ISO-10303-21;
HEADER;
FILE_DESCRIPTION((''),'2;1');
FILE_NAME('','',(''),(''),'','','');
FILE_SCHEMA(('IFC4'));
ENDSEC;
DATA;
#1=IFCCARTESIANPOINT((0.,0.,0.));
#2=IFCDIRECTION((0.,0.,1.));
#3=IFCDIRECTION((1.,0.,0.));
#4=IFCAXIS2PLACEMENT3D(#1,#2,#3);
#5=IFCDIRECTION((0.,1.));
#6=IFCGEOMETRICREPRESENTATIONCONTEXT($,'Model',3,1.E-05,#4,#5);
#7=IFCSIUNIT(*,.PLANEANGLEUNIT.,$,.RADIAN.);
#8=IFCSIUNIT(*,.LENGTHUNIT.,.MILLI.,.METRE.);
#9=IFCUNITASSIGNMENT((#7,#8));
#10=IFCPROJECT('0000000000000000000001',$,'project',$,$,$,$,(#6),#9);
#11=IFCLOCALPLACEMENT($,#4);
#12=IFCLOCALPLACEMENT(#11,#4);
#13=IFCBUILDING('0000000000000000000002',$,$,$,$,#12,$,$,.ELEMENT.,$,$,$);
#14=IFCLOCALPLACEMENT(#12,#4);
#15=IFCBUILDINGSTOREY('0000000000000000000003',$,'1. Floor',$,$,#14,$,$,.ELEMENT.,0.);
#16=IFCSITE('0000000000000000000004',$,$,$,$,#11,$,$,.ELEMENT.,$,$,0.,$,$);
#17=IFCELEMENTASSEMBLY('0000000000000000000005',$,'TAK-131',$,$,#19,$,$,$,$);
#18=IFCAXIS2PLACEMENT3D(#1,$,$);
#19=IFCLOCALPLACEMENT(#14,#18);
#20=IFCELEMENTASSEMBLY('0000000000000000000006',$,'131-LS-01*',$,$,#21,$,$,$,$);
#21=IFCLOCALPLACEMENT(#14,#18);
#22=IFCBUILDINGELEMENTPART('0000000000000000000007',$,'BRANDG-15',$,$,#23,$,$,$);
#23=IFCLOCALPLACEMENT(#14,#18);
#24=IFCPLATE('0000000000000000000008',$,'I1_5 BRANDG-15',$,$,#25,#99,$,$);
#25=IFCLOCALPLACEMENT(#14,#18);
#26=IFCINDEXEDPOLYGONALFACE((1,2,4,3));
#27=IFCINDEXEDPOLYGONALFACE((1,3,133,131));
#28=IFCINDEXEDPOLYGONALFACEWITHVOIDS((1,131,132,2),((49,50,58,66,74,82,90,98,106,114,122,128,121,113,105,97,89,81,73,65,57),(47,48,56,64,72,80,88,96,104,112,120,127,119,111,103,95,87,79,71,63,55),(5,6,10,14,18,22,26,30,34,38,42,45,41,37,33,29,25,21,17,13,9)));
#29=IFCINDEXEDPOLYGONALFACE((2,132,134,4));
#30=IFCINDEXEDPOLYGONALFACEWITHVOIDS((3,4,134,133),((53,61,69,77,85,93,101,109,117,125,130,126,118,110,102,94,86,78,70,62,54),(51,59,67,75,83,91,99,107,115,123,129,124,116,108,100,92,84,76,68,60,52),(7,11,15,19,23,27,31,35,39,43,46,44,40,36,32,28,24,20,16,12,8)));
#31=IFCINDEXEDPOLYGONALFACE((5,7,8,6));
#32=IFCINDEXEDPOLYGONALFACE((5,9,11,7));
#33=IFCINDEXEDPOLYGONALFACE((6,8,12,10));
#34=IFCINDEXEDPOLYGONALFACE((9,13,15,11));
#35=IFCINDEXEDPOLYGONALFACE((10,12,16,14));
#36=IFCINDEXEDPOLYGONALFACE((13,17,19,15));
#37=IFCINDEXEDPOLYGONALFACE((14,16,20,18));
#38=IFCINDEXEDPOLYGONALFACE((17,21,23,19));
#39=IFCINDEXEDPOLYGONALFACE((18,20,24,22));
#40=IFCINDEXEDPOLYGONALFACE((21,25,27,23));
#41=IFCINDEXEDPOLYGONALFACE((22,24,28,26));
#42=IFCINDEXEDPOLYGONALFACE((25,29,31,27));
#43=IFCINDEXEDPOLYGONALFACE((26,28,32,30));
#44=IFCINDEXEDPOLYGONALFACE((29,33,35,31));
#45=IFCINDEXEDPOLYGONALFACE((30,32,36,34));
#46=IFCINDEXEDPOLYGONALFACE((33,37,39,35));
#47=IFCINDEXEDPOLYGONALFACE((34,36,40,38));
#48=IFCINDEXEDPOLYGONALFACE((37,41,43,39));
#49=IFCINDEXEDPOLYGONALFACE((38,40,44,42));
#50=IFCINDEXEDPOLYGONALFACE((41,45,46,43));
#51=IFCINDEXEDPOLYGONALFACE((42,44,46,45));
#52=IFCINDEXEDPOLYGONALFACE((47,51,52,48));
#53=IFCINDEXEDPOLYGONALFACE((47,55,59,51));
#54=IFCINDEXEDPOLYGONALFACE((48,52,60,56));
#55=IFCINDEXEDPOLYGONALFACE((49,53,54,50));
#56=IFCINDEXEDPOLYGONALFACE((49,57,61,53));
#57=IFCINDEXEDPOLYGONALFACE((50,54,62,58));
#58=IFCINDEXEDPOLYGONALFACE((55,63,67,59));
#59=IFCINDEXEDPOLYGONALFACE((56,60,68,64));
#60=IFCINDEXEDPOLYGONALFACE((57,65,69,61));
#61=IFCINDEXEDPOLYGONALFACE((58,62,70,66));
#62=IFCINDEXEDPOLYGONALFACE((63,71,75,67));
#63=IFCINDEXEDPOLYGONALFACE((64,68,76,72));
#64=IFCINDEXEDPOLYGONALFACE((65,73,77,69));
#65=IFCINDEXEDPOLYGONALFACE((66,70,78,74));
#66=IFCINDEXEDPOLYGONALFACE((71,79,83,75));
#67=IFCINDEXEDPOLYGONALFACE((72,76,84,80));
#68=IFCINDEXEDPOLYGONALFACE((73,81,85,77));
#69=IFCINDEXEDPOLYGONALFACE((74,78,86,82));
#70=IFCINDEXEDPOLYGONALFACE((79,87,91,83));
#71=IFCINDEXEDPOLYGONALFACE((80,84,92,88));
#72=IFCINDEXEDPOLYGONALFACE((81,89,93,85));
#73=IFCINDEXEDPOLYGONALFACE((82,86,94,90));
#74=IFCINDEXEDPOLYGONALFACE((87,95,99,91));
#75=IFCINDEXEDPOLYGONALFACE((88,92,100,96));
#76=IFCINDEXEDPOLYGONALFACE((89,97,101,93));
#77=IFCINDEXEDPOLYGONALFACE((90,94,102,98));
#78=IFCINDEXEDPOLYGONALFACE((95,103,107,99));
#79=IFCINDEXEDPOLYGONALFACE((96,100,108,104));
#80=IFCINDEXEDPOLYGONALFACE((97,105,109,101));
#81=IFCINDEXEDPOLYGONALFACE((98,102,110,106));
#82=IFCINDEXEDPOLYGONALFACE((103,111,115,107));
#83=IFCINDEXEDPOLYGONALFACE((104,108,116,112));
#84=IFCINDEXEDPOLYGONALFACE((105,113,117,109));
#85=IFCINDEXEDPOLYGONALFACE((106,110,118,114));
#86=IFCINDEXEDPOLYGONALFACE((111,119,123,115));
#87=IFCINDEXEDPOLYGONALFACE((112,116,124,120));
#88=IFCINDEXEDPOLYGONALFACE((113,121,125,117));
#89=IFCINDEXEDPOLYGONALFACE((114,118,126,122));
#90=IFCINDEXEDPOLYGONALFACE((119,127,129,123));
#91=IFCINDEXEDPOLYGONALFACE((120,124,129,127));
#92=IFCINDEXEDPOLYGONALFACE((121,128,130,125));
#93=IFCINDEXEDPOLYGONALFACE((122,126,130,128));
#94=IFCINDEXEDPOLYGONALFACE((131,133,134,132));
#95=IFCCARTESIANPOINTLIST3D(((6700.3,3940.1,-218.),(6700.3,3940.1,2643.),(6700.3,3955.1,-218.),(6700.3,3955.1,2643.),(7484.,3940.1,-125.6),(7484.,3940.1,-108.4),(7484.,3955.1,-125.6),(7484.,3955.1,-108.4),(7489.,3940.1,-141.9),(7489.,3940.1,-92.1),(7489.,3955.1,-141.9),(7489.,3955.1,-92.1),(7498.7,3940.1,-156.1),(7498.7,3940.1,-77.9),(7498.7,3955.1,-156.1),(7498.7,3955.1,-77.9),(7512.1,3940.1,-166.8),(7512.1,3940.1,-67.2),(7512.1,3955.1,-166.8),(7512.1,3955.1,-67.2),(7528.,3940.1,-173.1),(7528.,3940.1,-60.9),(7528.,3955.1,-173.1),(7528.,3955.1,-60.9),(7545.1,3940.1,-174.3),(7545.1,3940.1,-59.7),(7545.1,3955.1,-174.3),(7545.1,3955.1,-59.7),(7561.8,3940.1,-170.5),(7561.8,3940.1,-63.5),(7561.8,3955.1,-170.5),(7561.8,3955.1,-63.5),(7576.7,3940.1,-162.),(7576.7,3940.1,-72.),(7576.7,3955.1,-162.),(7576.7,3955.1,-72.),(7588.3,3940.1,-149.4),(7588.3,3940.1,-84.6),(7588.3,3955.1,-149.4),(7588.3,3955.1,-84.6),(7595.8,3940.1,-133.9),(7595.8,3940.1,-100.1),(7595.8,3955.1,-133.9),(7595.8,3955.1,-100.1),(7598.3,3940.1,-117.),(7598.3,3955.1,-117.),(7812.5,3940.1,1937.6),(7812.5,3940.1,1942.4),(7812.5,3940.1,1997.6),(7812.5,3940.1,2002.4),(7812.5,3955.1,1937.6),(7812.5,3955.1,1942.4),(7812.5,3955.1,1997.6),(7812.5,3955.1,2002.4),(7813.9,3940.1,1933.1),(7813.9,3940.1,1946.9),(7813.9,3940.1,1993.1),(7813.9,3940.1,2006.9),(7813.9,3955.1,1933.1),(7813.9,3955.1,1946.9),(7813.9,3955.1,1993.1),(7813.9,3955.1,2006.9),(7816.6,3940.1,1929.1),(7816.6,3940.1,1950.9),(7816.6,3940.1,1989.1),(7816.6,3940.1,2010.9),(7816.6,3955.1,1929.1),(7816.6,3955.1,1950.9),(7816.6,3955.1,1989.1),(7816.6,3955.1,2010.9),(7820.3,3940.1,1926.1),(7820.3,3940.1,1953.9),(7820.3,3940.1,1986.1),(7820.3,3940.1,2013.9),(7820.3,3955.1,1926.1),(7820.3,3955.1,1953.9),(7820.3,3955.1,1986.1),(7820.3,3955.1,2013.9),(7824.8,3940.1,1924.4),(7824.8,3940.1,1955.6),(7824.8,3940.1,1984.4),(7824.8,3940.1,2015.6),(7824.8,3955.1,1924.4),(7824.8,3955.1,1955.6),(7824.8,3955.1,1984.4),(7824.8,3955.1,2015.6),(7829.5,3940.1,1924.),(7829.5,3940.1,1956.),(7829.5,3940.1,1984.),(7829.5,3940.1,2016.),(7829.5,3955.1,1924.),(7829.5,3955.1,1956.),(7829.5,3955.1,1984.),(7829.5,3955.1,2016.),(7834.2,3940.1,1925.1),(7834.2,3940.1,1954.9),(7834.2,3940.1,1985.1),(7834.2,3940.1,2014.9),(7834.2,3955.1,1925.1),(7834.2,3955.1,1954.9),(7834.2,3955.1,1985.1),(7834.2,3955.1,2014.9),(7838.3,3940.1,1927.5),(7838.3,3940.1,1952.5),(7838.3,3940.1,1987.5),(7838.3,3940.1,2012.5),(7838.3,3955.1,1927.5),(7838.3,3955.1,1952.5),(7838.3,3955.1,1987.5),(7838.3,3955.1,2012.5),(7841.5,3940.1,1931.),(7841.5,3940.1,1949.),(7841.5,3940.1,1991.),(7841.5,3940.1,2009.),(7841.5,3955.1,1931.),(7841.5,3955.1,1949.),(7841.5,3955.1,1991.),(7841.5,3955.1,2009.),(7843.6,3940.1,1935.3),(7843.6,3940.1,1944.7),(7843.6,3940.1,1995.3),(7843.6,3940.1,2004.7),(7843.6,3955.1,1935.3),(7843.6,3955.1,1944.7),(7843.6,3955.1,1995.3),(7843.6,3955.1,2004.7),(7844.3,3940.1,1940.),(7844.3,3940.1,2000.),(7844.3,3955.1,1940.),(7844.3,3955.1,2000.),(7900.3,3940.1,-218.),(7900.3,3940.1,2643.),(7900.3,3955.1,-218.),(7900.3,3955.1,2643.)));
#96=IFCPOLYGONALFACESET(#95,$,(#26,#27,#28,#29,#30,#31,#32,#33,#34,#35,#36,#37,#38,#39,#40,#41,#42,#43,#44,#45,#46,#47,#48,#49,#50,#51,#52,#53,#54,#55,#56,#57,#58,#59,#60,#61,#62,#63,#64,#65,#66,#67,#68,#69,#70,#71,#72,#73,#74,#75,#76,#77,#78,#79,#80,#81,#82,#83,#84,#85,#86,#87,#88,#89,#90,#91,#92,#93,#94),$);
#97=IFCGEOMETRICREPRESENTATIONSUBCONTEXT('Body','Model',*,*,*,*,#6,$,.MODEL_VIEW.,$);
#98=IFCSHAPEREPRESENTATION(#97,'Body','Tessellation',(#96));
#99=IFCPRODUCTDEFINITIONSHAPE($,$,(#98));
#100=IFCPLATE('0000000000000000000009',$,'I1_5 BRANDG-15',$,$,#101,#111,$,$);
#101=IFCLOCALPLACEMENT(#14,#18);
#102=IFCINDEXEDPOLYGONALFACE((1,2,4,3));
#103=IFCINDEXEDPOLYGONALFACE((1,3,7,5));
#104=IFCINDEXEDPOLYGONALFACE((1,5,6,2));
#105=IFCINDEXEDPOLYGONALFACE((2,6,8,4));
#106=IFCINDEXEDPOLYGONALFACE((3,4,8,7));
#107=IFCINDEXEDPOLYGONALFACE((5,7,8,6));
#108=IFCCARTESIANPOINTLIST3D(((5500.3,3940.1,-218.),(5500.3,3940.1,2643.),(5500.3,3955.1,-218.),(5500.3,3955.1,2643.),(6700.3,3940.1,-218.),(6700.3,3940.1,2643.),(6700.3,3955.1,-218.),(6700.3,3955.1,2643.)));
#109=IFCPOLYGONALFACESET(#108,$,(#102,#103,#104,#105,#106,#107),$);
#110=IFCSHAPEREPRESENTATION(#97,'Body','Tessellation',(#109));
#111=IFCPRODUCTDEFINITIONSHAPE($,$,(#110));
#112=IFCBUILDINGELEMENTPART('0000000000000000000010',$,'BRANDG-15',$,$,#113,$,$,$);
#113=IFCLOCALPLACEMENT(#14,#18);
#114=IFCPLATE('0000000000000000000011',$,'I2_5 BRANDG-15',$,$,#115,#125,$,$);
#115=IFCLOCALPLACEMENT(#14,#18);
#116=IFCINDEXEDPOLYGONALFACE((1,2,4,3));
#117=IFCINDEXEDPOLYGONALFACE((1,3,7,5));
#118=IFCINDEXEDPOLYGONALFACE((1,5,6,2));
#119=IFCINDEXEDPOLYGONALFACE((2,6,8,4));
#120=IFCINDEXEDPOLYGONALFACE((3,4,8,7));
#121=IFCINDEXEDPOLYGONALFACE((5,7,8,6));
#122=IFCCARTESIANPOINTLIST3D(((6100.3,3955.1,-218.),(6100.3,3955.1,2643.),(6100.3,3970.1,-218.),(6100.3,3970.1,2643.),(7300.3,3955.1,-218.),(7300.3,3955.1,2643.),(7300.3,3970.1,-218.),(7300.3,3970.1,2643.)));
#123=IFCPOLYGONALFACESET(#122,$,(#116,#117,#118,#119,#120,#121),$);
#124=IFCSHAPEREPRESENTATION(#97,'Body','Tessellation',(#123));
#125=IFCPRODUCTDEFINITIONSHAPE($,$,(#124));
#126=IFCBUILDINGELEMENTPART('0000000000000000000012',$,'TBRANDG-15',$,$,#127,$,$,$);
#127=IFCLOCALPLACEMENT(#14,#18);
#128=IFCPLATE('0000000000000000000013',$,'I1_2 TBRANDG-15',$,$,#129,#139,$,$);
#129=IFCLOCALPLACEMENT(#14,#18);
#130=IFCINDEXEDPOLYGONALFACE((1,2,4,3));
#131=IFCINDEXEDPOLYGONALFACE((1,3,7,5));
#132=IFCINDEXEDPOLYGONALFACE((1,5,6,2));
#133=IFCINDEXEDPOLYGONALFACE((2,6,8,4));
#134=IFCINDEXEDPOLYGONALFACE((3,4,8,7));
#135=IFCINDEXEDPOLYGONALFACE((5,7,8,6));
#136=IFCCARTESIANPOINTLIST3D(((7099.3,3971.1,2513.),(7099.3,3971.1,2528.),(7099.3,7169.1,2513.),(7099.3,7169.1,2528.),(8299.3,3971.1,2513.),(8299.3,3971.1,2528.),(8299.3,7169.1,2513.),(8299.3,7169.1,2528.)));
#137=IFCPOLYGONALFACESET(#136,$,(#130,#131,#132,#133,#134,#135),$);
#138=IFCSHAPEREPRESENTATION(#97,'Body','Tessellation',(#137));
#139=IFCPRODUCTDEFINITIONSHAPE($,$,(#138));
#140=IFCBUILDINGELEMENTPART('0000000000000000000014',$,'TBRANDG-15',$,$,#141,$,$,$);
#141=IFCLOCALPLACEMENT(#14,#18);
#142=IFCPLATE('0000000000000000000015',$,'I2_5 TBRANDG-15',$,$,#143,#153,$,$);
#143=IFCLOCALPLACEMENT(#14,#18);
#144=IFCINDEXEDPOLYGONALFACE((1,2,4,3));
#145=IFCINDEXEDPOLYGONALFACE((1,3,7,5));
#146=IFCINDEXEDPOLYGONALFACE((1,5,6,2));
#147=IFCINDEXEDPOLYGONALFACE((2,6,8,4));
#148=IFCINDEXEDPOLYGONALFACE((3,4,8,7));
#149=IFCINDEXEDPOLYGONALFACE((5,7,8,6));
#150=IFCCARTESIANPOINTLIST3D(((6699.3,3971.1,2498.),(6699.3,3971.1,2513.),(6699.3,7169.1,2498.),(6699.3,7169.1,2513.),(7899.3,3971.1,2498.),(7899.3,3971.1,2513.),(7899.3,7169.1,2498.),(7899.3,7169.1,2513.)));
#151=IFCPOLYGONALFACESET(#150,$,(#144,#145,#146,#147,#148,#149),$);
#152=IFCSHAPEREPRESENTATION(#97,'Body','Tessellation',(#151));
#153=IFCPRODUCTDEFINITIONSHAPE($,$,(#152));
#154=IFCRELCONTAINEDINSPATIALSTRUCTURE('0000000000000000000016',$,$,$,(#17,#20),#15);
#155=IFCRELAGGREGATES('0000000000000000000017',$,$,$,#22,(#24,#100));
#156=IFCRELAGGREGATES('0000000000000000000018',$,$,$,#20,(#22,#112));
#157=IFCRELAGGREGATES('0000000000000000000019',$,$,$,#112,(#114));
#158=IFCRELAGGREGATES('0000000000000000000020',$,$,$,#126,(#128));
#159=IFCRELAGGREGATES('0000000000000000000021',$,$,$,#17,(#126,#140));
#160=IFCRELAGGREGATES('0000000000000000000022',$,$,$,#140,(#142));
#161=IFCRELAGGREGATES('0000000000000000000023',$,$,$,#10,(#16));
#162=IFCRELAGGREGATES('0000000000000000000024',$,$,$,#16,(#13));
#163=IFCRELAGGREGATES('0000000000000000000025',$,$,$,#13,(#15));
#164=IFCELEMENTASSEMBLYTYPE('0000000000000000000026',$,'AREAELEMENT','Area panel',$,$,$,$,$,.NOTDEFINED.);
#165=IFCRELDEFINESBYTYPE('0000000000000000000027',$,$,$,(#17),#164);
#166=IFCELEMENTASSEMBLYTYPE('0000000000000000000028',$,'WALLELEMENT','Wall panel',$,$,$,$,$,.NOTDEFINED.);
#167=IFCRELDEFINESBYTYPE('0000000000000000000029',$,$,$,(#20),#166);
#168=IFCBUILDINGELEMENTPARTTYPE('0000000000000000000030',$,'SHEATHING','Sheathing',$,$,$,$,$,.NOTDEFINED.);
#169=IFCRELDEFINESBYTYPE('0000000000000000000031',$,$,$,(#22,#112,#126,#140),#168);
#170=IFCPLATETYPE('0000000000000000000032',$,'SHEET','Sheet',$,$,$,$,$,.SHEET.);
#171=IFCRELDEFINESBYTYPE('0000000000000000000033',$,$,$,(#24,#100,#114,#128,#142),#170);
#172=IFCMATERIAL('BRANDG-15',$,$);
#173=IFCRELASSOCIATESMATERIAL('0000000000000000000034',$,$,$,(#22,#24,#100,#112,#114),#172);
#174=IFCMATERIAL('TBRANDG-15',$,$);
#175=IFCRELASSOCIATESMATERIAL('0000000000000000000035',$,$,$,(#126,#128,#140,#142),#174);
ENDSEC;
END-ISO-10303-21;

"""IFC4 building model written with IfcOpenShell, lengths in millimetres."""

from ifc_helpers import new_model, si_unit, direction, frame, origin_with_axes, origin_2d_with_axis, place, context, subcontext, project, spatial, rectangle, circle, extrude, boolean, material, type_object, element, aggregate, save


model = new_model("IFC4")

# Units and contexts
model_context = context("Model", 3, precision=1e-05, world=origin_with_axes(), true_north=direction((0.0, 1.0)))
body_context = subcontext(model_context, "Body", "Model", "MODEL_VIEW")
ifc_project = project(units=[si_unit("PLANEANGLEUNIT", "RADIAN"), si_unit("LENGTHUNIT", "METRE", prefix="MILLI")], contexts=[model_context])

# Site, building, storey
site_placement = place(None, origin_with_axes())
site = spatial("IfcSite", under=ifc_project, at=site_placement, CompositionType="ELEMENT", RefElevation=0.0)
building_placement = place(site_placement, origin_with_axes())
building = spatial("IfcBuilding", under=site, at=building_placement, CompositionType="ELEMENT")
storey_placement = place(building_placement, origin_with_axes())
storey = spatial("IfcBuildingStorey", under=building, at=storey_placement, Name="1. Floor", CompositionType="ELEMENT", Elevation=0.0)

# Element assembly
element_assembly_type_1 = type_object("IfcElementAssemblyType", Name="AREAELEMENT", Description="Area panel", PredefinedType="NOTDEFINED")
assembly_1_placement = place(storey_placement, origin_with_axes())
assembly_1 = element("IfcElementAssembly", 1, at=assembly_1_placement, inside=storey, type_object=element_assembly_type_1, Name="TAK-131")

# Element assembly, building element parts, plates
element_assembly_type_2 = type_object("IfcElementAssemblyType", Name="WALLELEMENT", Description="Wall panel", PredefinedType="NOTDEFINED")
assembly_2_placement = place(storey_placement, origin_with_axes())
assembly_2 = element("IfcElementAssembly", 2, at=assembly_2_placement, inside=storey, type_object=element_assembly_type_2, Name="131-LS-01*")
ifc_material_1 = material(Name="BRANDG-15")
building_element_part_type_1 = type_object("IfcBuildingElementPartType", Name="SHEATHING", Description="Sheathing", PredefinedType="NOTDEFINED")
building_element_part_1_placement = place(storey_placement, origin_with_axes())
building_element_part_1 = element("IfcBuildingElementPart", 3, at=building_element_part_1_placement, type_object=building_element_part_type_1, material=ifc_material_1, Name="BRANDG-15")
plate_type_1 = type_object("IfcPlateType", Name="SHEET", Description="Sheet", PredefinedType="SHEET")
plate_1_placement = place(storey_placement, frame((7300.3, 3940.1, 4782.0), z_axis=(0.0, -1.0, 0.0), x_axis=(1.0, 0.0, 0.0)))
plate_1 = element("IfcPlate", 4, at=plate_1_placement, type_object=plate_type_1, material=ifc_material_1, Name="I1_5 BRANDG-15", context=body_context, shape_type="CSG", body=[
    boolean("DIFFERENCE", boolean("DIFFERENCE", boolean("DIFFERENCE", extrude(rectangle(XDim=15.0, YDim=1200.0, at=origin_2d_with_axis()), frame((0.0, -5000.0, -7.5), z_axis=(0.0, 1.0, 0.0), x_axis=(0.0, 0.0, 1.0)), (0.0, 0.0, 1.0), 2861.0), extrude(circle(Radius=16.0, at=origin_2d_with_axis()), frame((528.0, -2842.0, -31.0), z_axis=(0.0, 0.0, -1.0), x_axis=(1.0, 0.0, 0.0)), (0.0, 0.0, -1.0), 64.5)), extrude(circle(Radius=16.0, at=origin_2d_with_axis()), frame((528.0, -2782.0, -31.0), z_axis=(0.0, 0.0, -1.0), x_axis=(1.0, 0.0, 0.0)), (0.0, 0.0, -1.0), 64.5)), extrude(circle(Radius=57.5, at=origin_2d_with_axis()), frame((240.5, -4899.0, -31.0), z_axis=(0.0, 0.0, -1.0), x_axis=(1.0, 0.0, 0.0)), (0.0, 0.0, -1.0), 64.5)),
])
plate_2_placement = place(storey_placement, frame((6100.3, 3940.1, 4782.0), z_axis=(0.0, -1.0, 0.0), x_axis=(1.0, 0.0, 0.0)))
plate_2 = element("IfcPlate", 5, at=plate_2_placement, type_object=plate_type_1, material=ifc_material_1, Name="I1_5 BRANDG-15", context=body_context, shape_type="SweptSolid", body=[
    extrude(rectangle(XDim=15.0, YDim=1200.0, at=origin_2d_with_axis()), frame((0.0, -5000.0, -7.5), z_axis=(0.0, 1.0, 0.0), x_axis=(0.0, 0.0, 1.0)), (0.0, 0.0, 1.0), 2861.0),
])
aggregate(building_element_part_1, [plate_1, plate_2])
building_element_part_2_placement = place(storey_placement, origin_with_axes())
building_element_part_2 = element("IfcBuildingElementPart", 6, at=building_element_part_2_placement, type_object=building_element_part_type_1, material=ifc_material_1, Name="BRANDG-15")
aggregate(assembly_2, [building_element_part_1, building_element_part_2])
plate_3_placement = place(storey_placement, frame((6700.3, 3955.1, 4782.0), z_axis=(0.0, -1.0, 0.0), x_axis=(1.0, 0.0, 0.0)))
plate_3 = element("IfcPlate", 7, at=plate_3_placement, type_object=plate_type_1, material=ifc_material_1, Name="I2_5 BRANDG-15", context=body_context, shape_type="SweptSolid", body=[
    extrude(rectangle(XDim=15.0, YDim=1200.0, at=origin_2d_with_axis()), frame((0.0, -5000.0, -7.5), z_axis=(0.0, 1.0, 0.0), x_axis=(0.0, 0.0, 1.0)), (0.0, 0.0, 1.0), 2861.0),
])
aggregate(building_element_part_2, [plate_3])

# Building element part, plate
ifc_material_2 = material(Name="TBRANDG-15")
building_element_part_3_placement = place(storey_placement, origin_with_axes())
building_element_part_3 = element("IfcBuildingElementPart", 8, at=building_element_part_3_placement, type_object=building_element_part_type_1, material=ifc_material_2, Name="TBRANDG-15")
plate_4_placement = place(storey_placement, frame((7699.3, 4669.1, 2528.0), z_axis=(0.0, 0.0, 1.0), x_axis=(-1.0, 0.0, 0.0)))
plate_4 = element("IfcPlate", 9, at=plate_4_placement, type_object=plate_type_1, material=ifc_material_2, Name="I1_2 TBRANDG-15", context=body_context, shape_type="SweptSolid", body=[
    extrude(rectangle(XDim=15.0, YDim=1200.0, at=origin_2d_with_axis()), frame((0.0, -2500.0, -7.5), z_axis=(0.0, 1.0, 0.0), x_axis=(0.0, 0.0, 1.0)), (0.0, 0.0, 1.0), 3198.0),
])
aggregate(building_element_part_3, [plate_4])

# Building element part
building_element_part_4_placement = place(storey_placement, origin_with_axes())
building_element_part_4 = element("IfcBuildingElementPart", 10, at=building_element_part_4_placement, type_object=building_element_part_type_1, material=ifc_material_2, Name="TBRANDG-15")
aggregate(assembly_1, [building_element_part_3, building_element_part_4])

# Plate
plate_5_placement = place(storey_placement, frame((7299.3, 4669.1, 2513.0), z_axis=(0.0, 0.0, 1.0), x_axis=(-1.0, 0.0, 0.0)))
plate_5 = element("IfcPlate", 11, at=plate_5_placement, type_object=plate_type_1, material=ifc_material_2, Name="I2_5 TBRANDG-15", context=body_context, shape_type="SweptSolid", body=[
    extrude(rectangle(XDim=15.0, YDim=1200.0, at=origin_2d_with_axis()), frame((0.0, -2500.0, -7.5), z_axis=(0.0, 1.0, 0.0), x_axis=(0.0, 0.0, 1.0)), (0.0, 0.0, 1.0), 3198.0),
])
aggregate(building_element_part_4, [plate_5])

save(model, "model.ifc")
